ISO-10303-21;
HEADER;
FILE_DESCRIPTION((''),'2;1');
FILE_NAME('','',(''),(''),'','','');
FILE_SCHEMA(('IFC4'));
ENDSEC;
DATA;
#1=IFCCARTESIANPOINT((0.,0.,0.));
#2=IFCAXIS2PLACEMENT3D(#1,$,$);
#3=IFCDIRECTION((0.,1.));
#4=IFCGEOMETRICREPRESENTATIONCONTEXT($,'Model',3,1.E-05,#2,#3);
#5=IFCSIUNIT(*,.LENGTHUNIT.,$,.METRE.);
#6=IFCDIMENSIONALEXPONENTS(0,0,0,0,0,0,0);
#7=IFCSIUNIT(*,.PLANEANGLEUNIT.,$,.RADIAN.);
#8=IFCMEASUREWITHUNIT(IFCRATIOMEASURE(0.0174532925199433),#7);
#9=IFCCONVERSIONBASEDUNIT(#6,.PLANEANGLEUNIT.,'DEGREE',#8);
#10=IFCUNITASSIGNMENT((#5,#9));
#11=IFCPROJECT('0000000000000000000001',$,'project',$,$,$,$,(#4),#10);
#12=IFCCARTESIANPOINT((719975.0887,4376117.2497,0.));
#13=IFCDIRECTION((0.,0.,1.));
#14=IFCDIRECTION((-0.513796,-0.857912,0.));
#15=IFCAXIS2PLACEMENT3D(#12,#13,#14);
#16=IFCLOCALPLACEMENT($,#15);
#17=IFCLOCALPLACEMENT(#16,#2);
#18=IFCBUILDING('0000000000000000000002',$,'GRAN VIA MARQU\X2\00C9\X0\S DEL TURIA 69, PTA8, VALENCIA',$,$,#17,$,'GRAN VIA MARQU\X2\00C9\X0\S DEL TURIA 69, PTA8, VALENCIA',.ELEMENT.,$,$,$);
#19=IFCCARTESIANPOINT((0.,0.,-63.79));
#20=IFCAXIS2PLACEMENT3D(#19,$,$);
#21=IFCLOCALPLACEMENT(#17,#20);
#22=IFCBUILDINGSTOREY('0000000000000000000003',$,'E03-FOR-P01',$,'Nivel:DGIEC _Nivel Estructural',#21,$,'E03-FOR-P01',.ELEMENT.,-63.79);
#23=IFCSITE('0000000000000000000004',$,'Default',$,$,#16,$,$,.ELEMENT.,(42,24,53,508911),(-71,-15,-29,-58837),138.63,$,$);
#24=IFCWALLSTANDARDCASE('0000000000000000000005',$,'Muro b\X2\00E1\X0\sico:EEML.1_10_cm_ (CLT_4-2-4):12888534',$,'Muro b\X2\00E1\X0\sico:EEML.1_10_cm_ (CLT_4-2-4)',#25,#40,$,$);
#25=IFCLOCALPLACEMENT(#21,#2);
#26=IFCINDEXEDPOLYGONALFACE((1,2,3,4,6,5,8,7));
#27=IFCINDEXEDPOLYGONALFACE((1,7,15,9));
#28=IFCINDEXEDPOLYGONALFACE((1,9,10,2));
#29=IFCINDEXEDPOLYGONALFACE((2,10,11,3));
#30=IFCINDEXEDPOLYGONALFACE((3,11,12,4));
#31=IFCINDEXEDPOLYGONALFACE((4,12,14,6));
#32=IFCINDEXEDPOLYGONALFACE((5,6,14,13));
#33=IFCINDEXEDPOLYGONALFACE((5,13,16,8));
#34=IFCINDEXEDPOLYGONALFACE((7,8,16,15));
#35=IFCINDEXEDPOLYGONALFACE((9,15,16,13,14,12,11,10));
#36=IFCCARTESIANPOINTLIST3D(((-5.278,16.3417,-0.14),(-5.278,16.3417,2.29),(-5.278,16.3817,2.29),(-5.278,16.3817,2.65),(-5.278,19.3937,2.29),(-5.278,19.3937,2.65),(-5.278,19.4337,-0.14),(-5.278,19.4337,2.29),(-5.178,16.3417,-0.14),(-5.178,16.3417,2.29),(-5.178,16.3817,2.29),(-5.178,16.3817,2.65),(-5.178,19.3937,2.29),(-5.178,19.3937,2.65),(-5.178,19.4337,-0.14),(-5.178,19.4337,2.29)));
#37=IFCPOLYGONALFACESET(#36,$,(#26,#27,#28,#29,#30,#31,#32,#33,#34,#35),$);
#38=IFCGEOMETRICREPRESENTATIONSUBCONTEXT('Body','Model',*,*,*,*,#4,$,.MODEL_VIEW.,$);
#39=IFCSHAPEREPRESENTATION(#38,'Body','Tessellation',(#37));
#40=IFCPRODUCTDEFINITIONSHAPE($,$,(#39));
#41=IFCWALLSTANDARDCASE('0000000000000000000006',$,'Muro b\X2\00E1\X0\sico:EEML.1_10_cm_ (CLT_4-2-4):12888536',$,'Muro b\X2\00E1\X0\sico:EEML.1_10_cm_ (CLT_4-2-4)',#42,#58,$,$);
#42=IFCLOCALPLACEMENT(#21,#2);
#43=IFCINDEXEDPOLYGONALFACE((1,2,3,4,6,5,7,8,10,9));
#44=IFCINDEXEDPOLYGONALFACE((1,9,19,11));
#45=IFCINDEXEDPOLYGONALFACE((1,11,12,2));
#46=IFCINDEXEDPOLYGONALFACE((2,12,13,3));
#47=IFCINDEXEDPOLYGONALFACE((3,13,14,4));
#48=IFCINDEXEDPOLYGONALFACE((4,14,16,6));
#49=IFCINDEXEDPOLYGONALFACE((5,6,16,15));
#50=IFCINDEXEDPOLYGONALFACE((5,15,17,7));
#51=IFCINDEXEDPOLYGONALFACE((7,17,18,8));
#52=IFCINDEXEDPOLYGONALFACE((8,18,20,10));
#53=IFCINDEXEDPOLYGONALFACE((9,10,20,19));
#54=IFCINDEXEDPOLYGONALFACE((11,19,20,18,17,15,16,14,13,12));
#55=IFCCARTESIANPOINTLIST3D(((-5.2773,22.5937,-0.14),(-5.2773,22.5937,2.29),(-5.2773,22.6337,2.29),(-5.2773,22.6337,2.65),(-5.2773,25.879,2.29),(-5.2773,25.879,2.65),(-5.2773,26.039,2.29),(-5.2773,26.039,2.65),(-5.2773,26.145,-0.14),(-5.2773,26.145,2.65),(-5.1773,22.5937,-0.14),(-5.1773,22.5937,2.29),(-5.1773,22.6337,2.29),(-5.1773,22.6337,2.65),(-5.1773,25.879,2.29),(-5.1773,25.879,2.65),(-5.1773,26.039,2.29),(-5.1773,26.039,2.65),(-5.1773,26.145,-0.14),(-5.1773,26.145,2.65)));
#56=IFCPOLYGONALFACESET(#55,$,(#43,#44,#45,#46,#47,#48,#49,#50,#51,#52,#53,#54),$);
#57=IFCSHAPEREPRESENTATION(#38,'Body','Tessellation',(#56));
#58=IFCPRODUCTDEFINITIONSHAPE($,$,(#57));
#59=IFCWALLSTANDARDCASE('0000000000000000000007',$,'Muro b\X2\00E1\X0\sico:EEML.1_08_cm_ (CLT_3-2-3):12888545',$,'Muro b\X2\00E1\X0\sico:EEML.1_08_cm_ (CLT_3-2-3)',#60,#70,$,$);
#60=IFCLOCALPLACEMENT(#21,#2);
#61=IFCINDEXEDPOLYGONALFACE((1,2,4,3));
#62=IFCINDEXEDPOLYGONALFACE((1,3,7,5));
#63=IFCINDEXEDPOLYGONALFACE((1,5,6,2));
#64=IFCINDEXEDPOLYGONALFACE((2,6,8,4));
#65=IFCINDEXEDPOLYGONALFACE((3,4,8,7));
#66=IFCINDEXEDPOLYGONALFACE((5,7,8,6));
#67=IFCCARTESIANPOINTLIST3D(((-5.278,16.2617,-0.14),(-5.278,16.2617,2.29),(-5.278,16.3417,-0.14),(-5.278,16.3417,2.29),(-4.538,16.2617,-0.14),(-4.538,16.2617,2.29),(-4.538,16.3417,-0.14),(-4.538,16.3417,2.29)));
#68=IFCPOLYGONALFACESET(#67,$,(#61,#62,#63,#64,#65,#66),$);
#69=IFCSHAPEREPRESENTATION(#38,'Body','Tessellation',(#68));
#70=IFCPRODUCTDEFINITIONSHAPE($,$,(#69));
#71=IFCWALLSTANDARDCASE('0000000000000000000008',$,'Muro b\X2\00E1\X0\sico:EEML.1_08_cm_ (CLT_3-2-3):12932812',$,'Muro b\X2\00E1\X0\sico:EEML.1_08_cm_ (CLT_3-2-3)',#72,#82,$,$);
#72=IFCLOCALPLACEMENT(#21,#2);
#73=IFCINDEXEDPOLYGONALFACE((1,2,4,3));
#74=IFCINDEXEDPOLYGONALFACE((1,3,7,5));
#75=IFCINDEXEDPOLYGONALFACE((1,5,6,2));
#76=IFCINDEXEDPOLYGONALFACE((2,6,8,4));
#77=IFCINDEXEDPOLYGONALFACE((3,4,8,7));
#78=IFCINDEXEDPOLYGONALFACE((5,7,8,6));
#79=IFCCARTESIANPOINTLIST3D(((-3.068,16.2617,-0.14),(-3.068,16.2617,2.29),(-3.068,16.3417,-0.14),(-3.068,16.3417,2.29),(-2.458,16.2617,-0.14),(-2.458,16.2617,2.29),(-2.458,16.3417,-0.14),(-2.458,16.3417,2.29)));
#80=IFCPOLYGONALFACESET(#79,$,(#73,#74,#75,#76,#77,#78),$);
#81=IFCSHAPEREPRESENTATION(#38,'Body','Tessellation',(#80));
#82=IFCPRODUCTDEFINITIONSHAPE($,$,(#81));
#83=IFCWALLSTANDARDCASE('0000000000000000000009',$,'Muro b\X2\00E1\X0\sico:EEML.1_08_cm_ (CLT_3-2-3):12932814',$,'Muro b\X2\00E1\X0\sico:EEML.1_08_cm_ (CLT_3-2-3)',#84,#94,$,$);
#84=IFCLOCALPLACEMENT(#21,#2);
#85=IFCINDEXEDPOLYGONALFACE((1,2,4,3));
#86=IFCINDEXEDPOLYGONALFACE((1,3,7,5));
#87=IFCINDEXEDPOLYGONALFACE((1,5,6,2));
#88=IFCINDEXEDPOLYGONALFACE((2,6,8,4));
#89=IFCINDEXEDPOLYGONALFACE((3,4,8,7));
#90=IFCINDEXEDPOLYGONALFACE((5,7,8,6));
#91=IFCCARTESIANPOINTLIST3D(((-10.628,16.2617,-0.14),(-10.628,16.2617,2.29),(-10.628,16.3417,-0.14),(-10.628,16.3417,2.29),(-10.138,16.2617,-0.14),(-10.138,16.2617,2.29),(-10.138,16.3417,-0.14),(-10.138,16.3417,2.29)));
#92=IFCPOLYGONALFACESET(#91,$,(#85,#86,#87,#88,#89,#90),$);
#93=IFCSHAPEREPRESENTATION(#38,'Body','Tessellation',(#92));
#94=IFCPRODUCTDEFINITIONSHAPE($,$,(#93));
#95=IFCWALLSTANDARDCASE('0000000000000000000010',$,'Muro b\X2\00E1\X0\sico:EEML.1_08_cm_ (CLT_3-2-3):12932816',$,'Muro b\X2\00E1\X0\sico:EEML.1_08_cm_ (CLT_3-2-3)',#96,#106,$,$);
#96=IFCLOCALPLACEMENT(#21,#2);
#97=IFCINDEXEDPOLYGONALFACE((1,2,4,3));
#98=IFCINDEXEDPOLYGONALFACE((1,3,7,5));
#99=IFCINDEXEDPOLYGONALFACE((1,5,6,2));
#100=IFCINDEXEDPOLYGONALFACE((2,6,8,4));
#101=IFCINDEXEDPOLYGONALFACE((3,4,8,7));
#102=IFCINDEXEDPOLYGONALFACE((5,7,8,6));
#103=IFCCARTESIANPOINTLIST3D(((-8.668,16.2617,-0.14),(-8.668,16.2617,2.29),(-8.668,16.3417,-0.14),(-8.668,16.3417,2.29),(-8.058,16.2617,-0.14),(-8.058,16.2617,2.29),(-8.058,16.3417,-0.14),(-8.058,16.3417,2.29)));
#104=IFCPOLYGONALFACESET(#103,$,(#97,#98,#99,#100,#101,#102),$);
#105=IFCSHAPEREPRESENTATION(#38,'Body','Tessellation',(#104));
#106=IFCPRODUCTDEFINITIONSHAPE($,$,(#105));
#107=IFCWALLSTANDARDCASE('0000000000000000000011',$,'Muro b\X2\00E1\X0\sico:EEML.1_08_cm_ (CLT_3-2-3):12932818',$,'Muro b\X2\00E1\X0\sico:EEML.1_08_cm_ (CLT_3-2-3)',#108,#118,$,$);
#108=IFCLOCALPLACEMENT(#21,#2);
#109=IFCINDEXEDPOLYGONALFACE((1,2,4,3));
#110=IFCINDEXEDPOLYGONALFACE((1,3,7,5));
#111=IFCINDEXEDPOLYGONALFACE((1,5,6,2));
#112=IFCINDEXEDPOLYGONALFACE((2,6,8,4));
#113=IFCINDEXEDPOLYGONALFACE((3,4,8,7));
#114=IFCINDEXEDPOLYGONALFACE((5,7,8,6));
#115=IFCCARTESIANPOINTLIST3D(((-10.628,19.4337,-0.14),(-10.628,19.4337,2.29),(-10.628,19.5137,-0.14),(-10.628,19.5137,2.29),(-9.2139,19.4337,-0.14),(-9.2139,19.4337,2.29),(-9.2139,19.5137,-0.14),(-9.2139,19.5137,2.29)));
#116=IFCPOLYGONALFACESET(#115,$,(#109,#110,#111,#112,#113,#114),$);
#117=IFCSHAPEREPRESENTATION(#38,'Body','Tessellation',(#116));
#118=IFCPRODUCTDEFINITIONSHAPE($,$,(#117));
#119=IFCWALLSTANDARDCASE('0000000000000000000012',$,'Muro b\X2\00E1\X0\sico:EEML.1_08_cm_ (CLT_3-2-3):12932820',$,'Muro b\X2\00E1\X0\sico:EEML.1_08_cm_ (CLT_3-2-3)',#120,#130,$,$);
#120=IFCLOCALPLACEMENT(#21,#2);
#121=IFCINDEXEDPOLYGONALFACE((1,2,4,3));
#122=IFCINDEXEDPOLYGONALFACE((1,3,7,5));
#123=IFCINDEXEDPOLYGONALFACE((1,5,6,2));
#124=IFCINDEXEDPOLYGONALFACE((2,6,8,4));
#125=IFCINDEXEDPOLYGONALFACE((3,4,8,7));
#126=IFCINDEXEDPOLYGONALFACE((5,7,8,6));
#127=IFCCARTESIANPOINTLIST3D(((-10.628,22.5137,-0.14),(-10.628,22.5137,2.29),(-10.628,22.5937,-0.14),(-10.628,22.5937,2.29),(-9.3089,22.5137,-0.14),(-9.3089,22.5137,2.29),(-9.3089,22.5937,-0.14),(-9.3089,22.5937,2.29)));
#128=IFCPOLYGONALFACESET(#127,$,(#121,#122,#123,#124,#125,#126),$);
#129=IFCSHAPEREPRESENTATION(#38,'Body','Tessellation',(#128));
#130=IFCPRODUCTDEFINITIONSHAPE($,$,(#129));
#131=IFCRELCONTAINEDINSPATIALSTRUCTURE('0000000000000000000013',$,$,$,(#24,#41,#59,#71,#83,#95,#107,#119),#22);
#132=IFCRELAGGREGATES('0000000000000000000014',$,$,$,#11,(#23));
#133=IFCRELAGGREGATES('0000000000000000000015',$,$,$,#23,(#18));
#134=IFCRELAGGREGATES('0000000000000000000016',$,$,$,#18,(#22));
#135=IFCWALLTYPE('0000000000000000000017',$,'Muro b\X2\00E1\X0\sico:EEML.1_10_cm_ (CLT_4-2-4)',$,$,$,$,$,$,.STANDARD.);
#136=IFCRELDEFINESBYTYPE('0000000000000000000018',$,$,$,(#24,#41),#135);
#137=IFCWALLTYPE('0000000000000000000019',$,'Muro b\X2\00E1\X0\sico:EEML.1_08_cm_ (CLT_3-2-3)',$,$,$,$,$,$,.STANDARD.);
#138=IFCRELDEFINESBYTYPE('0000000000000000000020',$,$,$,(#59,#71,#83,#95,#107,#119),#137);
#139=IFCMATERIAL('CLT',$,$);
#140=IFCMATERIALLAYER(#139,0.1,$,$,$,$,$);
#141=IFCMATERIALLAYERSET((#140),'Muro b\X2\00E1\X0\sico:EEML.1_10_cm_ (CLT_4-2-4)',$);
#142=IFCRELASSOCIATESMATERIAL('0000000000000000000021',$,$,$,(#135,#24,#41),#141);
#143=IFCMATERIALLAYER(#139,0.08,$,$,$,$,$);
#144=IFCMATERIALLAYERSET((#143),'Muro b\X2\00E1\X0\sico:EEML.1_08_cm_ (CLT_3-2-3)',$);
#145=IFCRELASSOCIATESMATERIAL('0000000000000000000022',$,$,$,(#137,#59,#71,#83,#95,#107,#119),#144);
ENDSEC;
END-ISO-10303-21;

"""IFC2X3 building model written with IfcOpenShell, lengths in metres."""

from ifc_helpers import new_model, entity, si_unit, converted_unit, direction, frame, frame_2d, origin, place, context, subcontext, project, spatial, rectangle, extrude, material, layer, layer_set, layer_usage, type_object, element, save


model = new_model("IFC2X3")

# Units and contexts
model_context = context("Model", 3, precision=1e-05, world=origin(), true_north=direction((0.0, 1.0)))
body_context = subcontext(model_context, "Body", "Model", "MODEL_VIEW")
ifc_project = project(units=[si_unit("LENGTHUNIT", "METRE"), converted_unit("PLANEANGLEUNIT", "DEGREE", entity("IfcRatioMeasure", 0.0174532925199433), si_unit("PLANEANGLEUNIT", "RADIAN"), dimensions=[0, 0, 0, 0, 0, 0, 0])], contexts=[model_context])

# Site, building, storey
site_placement = place(None, frame((719975.0887, 4376117.2497, 0.0), z_axis=(0.0, 0.0, 1.0), x_axis=(-0.513796, -0.857912, 0.0)))
site = spatial("IfcSite", under=ifc_project, at=site_placement, Name="Default", CompositionType="ELEMENT", RefLatitude=(42, 24, 53, 508911), RefLongitude=(-71, -15, -29, -58837), RefElevation=138.63)
building_placement = place(site_placement, origin())
building = spatial("IfcBuilding", under=site, at=building_placement, Name="GRAN VIA MARQUÉS DEL TURIA 69, PTA8, VALENCIA", LongName="GRAN VIA MARQUÉS DEL TURIA 69, PTA8, VALENCIA", CompositionType="ELEMENT")
storey_placement = place(building_placement, frame((0.0, 0.0, -63.79)))
storey = spatial("IfcBuildingStorey", under=building, at=storey_placement, Name="E03-FOR-P01", ObjectType="Nivel:DGIEC _Nivel Estructural", LongName="E03-FOR-P01", CompositionType="ELEMENT", Elevation=-63.79)

# Walls, openings
ifc_material_1 = material(Name="CLT")
ifc_layer_1 = layer(ifc_material_1, 0.1)
ifc_layer_set_1 = layer_set([ifc_layer_1], Name="Muro básico:EEML.1_10_cm_ (CLT_4-2-4)")
ifc_layer_usage_1 = layer_usage(ifc_layer_set_1, "AXIS2", "NEGATIVE", 0.05)
wall_type_1 = type_object("IfcWallType", Name="Muro básico:EEML.1_10_cm_ (CLT_4-2-4)", PredefinedType="STANDARD", material=ifc_layer_set_1)
wall_1_placement = place(storey_placement, frame((-5.228, 16.3417, -0.14), z_axis=(0.0, 0.0, 1.0), x_axis=(0.0, 1.0, 0.0)))
wall_1 = element("IfcWallStandardCase", 1, at=wall_1_placement, inside=storey, type_object=wall_type_1, material=ifc_layer_usage_1, Name="Muro básico:EEML.1_10_cm_ (CLT_4-2-4):12888534", ObjectType="Muro básico:EEML.1_10_cm_ (CLT_4-2-4)", context=body_context, shape_type="SweptSolid", body=[
    extrude(rectangle(XDim=3.092, YDim=0.1, at=frame_2d((1.546, 0.0), x_axis=(-1.0, 0.0))), origin(), (0.0, 0.0, 1.0), 2.79),
])
opening_1_placement = place(wall_1_placement, origin())
element("IfcOpeningElement", 2, at=opening_1_placement, cuts=wall_1, ObjectType="Opening", context=body_context, shape_type="SweptSolid", body=[
    extrude(rectangle(XDim=0.36, YDim=0.08, at=frame_2d((0.0, 0.0), x_axis=(1.0, 0.0))), frame((3.092, 0.05, 2.61), z_axis=(0.0, -1.0, 0.0), x_axis=(0.0, 0.0, 1.0)), (0.0, 0.0, 1.0), 0.1),
])
opening_2_placement = place(wall_1_placement, origin())
element("IfcOpeningElement", 3, at=opening_2_placement, cuts=wall_1, ObjectType="Opening", context=body_context, shape_type="SweptSolid", body=[
    extrude(rectangle(XDim=0.36, YDim=0.08, at=frame_2d((0.0, 0.0), x_axis=(0.0, 1.0))), frame((0.0, 0.05, 2.61), z_axis=(0.0, -1.0, 0.0), x_axis=(-1.0, 0.0, 0.0)), (0.0, 0.0, 1.0), 0.1),
])
ifc_layer_usage_2 = layer_usage(ifc_layer_set_1, "AXIS2", "NEGATIVE", 0.05)
wall_2_placement = place(storey_placement, frame((-5.2273, 22.5937, -0.14), z_axis=(0.0, 0.0, 1.0), x_axis=(0.0, 1.0, 0.0)))
wall_2 = element("IfcWallStandardCase", 4, at=wall_2_placement, inside=storey, type_object=wall_type_1, material=ifc_layer_usage_2, Name="Muro básico:EEML.1_10_cm_ (CLT_4-2-4):12888536", ObjectType="Muro básico:EEML.1_10_cm_ (CLT_4-2-4)", context=body_context, shape_type="SweptSolid", body=[
    extrude(rectangle(XDim=3.5513, YDim=0.1, at=frame_2d((1.7757, 0.0), x_axis=(-1.0, 0.0))), origin(), (0.0, 0.0, 1.0), 2.79),
])
opening_3_placement = place(wall_2_placement, origin())
element("IfcOpeningElement", 5, at=opening_3_placement, cuts=wall_2, ObjectType="Opening", context=body_context, shape_type="SweptSolid", body=[
    extrude(rectangle(XDim=0.36, YDim=0.16, at=frame_2d((0.0, 0.0), x_axis=(0.0, 1.0))), frame((3.3653, 0.05, 2.61), z_axis=(0.0, -1.0, 0.0), x_axis=(-1.0, 0.0, 0.0)), (0.0, 0.0, 1.0), 0.1),
])
opening_4_placement = place(wall_2_placement, origin())
element("IfcOpeningElement", 6, at=opening_4_placement, cuts=wall_2, ObjectType="Opening", context=body_context, shape_type="SweptSolid", body=[
    extrude(rectangle(XDim=0.36, YDim=0.08, at=frame_2d((0.0, 0.0), x_axis=(0.0, 1.0))), frame((0.0, 0.05, 2.61), z_axis=(0.0, -1.0, 0.0), x_axis=(-1.0, 0.0, 0.0)), (0.0, 0.0, 1.0), 0.1),
])

# Walls
ifc_layer_2 = layer(ifc_material_1, 0.08)
ifc_layer_set_2 = layer_set([ifc_layer_2], Name="Muro básico:EEML.1_08_cm_ (CLT_3-2-3)")
ifc_layer_usage_3 = layer_usage(ifc_layer_set_2, "AXIS2", "NEGATIVE", 0.04)
wall_type_2 = type_object("IfcWallType", Name="Muro básico:EEML.1_08_cm_ (CLT_3-2-3)", PredefinedType="STANDARD", material=ifc_layer_set_2)
wall_3_placement = place(storey_placement, frame((-4.538, 16.3017, -0.14), z_axis=(0.0, 0.0, 1.0), x_axis=(-1.0, 0.0, 0.0)))
element("IfcWallStandardCase", 7, at=wall_3_placement, inside=storey, type_object=wall_type_2, material=ifc_layer_usage_3, Name="Muro básico:EEML.1_08_cm_ (CLT_3-2-3):12888545", ObjectType="Muro básico:EEML.1_08_cm_ (CLT_3-2-3)", context=body_context, shape_type="SweptSolid", body=[
    extrude(rectangle(XDim=0.74, YDim=0.08, at=frame_2d((0.37, 0.0), x_axis=(-1.0, 0.0))), origin(), (0.0, 0.0, 1.0), 2.43),
])
ifc_layer_usage_4 = layer_usage(ifc_layer_set_2, "AXIS2", "NEGATIVE", 0.04)
wall_4_placement = place(storey_placement, frame((-2.458, 16.3017, -0.14), z_axis=(0.0, 0.0, 1.0), x_axis=(-1.0, 0.0, 0.0)))
element("IfcWallStandardCase", 8, at=wall_4_placement, inside=storey, type_object=wall_type_2, material=ifc_layer_usage_4, Name="Muro básico:EEML.1_08_cm_ (CLT_3-2-3):12932812", ObjectType="Muro básico:EEML.1_08_cm_ (CLT_3-2-3)", context=body_context, shape_type="SweptSolid", body=[
    extrude(rectangle(XDim=0.61, YDim=0.08, at=frame_2d((0.305, 0.0), x_axis=(-1.0, 0.0))), origin(), (0.0, 0.0, 1.0), 2.43),
])
ifc_layer_usage_5 = layer_usage(ifc_layer_set_2, "AXIS2", "NEGATIVE", 0.04)
wall_5_placement = place(storey_placement, frame((-10.138, 16.3017, -0.14), z_axis=(0.0, 0.0, 1.0), x_axis=(-1.0, 0.0, 0.0)))
element("IfcWallStandardCase", 9, at=wall_5_placement, inside=storey, type_object=wall_type_2, material=ifc_layer_usage_5, Name="Muro básico:EEML.1_08_cm_ (CLT_3-2-3):12932814", ObjectType="Muro básico:EEML.1_08_cm_ (CLT_3-2-3)", context=body_context, shape_type="SweptSolid", body=[
    extrude(rectangle(XDim=0.49, YDim=0.08, at=frame_2d((0.245, 0.0), x_axis=(-1.0, 0.0))), origin(), (0.0, 0.0, 1.0), 2.43),
])
ifc_layer_usage_6 = layer_usage(ifc_layer_set_2, "AXIS2", "NEGATIVE", 0.04)
wall_6_placement = place(storey_placement, frame((-8.058, 16.3017, -0.14), z_axis=(0.0, 0.0, 1.0), x_axis=(-1.0, 0.0, 0.0)))
element("IfcWallStandardCase", 10, at=wall_6_placement, inside=storey, type_object=wall_type_2, material=ifc_layer_usage_6, Name="Muro básico:EEML.1_08_cm_ (CLT_3-2-3):12932816", ObjectType="Muro básico:EEML.1_08_cm_ (CLT_3-2-3)", context=body_context, shape_type="SweptSolid", body=[
    extrude(rectangle(XDim=0.61, YDim=0.08, at=frame_2d((0.305, 0.0), x_axis=(-1.0, 0.0))), origin(), (0.0, 0.0, 1.0), 2.43),
])
ifc_layer_usage_7 = layer_usage(ifc_layer_set_2, "AXIS2", "NEGATIVE", 0.04)
wall_7_placement = place(storey_placement, frame((-9.2139, 19.4737, -0.14), z_axis=(0.0, 0.0, 1.0), x_axis=(-1.0, 0.0, 0.0)))
element("IfcWallStandardCase", 11, at=wall_7_placement, inside=storey, type_object=wall_type_2, material=ifc_layer_usage_7, Name="Muro básico:EEML.1_08_cm_ (CLT_3-2-3):12932818", ObjectType="Muro básico:EEML.1_08_cm_ (CLT_3-2-3)", context=body_context, shape_type="SweptSolid", body=[
    extrude(rectangle(XDim=1.4142, YDim=0.08, at=frame_2d((0.7071, 0.0), x_axis=(-1.0, 0.0))), origin(), (0.0, 0.0, 1.0), 2.43),
])
ifc_layer_usage_8 = layer_usage(ifc_layer_set_2, "AXIS2", "NEGATIVE", 0.04)
wall_8_placement = place(storey_placement, frame((-9.3089, 22.5537, -0.14), z_axis=(0.0, 0.0, 1.0), x_axis=(-1.0, 0.0, 0.0)))
element("IfcWallStandardCase", 12, at=wall_8_placement, inside=storey, type_object=wall_type_2, material=ifc_layer_usage_8, Name="Muro básico:EEML.1_08_cm_ (CLT_3-2-3):12932820", ObjectType="Muro básico:EEML.1_08_cm_ (CLT_3-2-3)", context=body_context, shape_type="SweptSolid", body=[
    extrude(rectangle(XDim=1.3192, YDim=0.08, at=frame_2d((0.6596, 0.0), x_axis=(-1.0, 0.0))), origin(), (0.0, 0.0, 1.0), 2.43),
])

save(model, "model.ifc")
